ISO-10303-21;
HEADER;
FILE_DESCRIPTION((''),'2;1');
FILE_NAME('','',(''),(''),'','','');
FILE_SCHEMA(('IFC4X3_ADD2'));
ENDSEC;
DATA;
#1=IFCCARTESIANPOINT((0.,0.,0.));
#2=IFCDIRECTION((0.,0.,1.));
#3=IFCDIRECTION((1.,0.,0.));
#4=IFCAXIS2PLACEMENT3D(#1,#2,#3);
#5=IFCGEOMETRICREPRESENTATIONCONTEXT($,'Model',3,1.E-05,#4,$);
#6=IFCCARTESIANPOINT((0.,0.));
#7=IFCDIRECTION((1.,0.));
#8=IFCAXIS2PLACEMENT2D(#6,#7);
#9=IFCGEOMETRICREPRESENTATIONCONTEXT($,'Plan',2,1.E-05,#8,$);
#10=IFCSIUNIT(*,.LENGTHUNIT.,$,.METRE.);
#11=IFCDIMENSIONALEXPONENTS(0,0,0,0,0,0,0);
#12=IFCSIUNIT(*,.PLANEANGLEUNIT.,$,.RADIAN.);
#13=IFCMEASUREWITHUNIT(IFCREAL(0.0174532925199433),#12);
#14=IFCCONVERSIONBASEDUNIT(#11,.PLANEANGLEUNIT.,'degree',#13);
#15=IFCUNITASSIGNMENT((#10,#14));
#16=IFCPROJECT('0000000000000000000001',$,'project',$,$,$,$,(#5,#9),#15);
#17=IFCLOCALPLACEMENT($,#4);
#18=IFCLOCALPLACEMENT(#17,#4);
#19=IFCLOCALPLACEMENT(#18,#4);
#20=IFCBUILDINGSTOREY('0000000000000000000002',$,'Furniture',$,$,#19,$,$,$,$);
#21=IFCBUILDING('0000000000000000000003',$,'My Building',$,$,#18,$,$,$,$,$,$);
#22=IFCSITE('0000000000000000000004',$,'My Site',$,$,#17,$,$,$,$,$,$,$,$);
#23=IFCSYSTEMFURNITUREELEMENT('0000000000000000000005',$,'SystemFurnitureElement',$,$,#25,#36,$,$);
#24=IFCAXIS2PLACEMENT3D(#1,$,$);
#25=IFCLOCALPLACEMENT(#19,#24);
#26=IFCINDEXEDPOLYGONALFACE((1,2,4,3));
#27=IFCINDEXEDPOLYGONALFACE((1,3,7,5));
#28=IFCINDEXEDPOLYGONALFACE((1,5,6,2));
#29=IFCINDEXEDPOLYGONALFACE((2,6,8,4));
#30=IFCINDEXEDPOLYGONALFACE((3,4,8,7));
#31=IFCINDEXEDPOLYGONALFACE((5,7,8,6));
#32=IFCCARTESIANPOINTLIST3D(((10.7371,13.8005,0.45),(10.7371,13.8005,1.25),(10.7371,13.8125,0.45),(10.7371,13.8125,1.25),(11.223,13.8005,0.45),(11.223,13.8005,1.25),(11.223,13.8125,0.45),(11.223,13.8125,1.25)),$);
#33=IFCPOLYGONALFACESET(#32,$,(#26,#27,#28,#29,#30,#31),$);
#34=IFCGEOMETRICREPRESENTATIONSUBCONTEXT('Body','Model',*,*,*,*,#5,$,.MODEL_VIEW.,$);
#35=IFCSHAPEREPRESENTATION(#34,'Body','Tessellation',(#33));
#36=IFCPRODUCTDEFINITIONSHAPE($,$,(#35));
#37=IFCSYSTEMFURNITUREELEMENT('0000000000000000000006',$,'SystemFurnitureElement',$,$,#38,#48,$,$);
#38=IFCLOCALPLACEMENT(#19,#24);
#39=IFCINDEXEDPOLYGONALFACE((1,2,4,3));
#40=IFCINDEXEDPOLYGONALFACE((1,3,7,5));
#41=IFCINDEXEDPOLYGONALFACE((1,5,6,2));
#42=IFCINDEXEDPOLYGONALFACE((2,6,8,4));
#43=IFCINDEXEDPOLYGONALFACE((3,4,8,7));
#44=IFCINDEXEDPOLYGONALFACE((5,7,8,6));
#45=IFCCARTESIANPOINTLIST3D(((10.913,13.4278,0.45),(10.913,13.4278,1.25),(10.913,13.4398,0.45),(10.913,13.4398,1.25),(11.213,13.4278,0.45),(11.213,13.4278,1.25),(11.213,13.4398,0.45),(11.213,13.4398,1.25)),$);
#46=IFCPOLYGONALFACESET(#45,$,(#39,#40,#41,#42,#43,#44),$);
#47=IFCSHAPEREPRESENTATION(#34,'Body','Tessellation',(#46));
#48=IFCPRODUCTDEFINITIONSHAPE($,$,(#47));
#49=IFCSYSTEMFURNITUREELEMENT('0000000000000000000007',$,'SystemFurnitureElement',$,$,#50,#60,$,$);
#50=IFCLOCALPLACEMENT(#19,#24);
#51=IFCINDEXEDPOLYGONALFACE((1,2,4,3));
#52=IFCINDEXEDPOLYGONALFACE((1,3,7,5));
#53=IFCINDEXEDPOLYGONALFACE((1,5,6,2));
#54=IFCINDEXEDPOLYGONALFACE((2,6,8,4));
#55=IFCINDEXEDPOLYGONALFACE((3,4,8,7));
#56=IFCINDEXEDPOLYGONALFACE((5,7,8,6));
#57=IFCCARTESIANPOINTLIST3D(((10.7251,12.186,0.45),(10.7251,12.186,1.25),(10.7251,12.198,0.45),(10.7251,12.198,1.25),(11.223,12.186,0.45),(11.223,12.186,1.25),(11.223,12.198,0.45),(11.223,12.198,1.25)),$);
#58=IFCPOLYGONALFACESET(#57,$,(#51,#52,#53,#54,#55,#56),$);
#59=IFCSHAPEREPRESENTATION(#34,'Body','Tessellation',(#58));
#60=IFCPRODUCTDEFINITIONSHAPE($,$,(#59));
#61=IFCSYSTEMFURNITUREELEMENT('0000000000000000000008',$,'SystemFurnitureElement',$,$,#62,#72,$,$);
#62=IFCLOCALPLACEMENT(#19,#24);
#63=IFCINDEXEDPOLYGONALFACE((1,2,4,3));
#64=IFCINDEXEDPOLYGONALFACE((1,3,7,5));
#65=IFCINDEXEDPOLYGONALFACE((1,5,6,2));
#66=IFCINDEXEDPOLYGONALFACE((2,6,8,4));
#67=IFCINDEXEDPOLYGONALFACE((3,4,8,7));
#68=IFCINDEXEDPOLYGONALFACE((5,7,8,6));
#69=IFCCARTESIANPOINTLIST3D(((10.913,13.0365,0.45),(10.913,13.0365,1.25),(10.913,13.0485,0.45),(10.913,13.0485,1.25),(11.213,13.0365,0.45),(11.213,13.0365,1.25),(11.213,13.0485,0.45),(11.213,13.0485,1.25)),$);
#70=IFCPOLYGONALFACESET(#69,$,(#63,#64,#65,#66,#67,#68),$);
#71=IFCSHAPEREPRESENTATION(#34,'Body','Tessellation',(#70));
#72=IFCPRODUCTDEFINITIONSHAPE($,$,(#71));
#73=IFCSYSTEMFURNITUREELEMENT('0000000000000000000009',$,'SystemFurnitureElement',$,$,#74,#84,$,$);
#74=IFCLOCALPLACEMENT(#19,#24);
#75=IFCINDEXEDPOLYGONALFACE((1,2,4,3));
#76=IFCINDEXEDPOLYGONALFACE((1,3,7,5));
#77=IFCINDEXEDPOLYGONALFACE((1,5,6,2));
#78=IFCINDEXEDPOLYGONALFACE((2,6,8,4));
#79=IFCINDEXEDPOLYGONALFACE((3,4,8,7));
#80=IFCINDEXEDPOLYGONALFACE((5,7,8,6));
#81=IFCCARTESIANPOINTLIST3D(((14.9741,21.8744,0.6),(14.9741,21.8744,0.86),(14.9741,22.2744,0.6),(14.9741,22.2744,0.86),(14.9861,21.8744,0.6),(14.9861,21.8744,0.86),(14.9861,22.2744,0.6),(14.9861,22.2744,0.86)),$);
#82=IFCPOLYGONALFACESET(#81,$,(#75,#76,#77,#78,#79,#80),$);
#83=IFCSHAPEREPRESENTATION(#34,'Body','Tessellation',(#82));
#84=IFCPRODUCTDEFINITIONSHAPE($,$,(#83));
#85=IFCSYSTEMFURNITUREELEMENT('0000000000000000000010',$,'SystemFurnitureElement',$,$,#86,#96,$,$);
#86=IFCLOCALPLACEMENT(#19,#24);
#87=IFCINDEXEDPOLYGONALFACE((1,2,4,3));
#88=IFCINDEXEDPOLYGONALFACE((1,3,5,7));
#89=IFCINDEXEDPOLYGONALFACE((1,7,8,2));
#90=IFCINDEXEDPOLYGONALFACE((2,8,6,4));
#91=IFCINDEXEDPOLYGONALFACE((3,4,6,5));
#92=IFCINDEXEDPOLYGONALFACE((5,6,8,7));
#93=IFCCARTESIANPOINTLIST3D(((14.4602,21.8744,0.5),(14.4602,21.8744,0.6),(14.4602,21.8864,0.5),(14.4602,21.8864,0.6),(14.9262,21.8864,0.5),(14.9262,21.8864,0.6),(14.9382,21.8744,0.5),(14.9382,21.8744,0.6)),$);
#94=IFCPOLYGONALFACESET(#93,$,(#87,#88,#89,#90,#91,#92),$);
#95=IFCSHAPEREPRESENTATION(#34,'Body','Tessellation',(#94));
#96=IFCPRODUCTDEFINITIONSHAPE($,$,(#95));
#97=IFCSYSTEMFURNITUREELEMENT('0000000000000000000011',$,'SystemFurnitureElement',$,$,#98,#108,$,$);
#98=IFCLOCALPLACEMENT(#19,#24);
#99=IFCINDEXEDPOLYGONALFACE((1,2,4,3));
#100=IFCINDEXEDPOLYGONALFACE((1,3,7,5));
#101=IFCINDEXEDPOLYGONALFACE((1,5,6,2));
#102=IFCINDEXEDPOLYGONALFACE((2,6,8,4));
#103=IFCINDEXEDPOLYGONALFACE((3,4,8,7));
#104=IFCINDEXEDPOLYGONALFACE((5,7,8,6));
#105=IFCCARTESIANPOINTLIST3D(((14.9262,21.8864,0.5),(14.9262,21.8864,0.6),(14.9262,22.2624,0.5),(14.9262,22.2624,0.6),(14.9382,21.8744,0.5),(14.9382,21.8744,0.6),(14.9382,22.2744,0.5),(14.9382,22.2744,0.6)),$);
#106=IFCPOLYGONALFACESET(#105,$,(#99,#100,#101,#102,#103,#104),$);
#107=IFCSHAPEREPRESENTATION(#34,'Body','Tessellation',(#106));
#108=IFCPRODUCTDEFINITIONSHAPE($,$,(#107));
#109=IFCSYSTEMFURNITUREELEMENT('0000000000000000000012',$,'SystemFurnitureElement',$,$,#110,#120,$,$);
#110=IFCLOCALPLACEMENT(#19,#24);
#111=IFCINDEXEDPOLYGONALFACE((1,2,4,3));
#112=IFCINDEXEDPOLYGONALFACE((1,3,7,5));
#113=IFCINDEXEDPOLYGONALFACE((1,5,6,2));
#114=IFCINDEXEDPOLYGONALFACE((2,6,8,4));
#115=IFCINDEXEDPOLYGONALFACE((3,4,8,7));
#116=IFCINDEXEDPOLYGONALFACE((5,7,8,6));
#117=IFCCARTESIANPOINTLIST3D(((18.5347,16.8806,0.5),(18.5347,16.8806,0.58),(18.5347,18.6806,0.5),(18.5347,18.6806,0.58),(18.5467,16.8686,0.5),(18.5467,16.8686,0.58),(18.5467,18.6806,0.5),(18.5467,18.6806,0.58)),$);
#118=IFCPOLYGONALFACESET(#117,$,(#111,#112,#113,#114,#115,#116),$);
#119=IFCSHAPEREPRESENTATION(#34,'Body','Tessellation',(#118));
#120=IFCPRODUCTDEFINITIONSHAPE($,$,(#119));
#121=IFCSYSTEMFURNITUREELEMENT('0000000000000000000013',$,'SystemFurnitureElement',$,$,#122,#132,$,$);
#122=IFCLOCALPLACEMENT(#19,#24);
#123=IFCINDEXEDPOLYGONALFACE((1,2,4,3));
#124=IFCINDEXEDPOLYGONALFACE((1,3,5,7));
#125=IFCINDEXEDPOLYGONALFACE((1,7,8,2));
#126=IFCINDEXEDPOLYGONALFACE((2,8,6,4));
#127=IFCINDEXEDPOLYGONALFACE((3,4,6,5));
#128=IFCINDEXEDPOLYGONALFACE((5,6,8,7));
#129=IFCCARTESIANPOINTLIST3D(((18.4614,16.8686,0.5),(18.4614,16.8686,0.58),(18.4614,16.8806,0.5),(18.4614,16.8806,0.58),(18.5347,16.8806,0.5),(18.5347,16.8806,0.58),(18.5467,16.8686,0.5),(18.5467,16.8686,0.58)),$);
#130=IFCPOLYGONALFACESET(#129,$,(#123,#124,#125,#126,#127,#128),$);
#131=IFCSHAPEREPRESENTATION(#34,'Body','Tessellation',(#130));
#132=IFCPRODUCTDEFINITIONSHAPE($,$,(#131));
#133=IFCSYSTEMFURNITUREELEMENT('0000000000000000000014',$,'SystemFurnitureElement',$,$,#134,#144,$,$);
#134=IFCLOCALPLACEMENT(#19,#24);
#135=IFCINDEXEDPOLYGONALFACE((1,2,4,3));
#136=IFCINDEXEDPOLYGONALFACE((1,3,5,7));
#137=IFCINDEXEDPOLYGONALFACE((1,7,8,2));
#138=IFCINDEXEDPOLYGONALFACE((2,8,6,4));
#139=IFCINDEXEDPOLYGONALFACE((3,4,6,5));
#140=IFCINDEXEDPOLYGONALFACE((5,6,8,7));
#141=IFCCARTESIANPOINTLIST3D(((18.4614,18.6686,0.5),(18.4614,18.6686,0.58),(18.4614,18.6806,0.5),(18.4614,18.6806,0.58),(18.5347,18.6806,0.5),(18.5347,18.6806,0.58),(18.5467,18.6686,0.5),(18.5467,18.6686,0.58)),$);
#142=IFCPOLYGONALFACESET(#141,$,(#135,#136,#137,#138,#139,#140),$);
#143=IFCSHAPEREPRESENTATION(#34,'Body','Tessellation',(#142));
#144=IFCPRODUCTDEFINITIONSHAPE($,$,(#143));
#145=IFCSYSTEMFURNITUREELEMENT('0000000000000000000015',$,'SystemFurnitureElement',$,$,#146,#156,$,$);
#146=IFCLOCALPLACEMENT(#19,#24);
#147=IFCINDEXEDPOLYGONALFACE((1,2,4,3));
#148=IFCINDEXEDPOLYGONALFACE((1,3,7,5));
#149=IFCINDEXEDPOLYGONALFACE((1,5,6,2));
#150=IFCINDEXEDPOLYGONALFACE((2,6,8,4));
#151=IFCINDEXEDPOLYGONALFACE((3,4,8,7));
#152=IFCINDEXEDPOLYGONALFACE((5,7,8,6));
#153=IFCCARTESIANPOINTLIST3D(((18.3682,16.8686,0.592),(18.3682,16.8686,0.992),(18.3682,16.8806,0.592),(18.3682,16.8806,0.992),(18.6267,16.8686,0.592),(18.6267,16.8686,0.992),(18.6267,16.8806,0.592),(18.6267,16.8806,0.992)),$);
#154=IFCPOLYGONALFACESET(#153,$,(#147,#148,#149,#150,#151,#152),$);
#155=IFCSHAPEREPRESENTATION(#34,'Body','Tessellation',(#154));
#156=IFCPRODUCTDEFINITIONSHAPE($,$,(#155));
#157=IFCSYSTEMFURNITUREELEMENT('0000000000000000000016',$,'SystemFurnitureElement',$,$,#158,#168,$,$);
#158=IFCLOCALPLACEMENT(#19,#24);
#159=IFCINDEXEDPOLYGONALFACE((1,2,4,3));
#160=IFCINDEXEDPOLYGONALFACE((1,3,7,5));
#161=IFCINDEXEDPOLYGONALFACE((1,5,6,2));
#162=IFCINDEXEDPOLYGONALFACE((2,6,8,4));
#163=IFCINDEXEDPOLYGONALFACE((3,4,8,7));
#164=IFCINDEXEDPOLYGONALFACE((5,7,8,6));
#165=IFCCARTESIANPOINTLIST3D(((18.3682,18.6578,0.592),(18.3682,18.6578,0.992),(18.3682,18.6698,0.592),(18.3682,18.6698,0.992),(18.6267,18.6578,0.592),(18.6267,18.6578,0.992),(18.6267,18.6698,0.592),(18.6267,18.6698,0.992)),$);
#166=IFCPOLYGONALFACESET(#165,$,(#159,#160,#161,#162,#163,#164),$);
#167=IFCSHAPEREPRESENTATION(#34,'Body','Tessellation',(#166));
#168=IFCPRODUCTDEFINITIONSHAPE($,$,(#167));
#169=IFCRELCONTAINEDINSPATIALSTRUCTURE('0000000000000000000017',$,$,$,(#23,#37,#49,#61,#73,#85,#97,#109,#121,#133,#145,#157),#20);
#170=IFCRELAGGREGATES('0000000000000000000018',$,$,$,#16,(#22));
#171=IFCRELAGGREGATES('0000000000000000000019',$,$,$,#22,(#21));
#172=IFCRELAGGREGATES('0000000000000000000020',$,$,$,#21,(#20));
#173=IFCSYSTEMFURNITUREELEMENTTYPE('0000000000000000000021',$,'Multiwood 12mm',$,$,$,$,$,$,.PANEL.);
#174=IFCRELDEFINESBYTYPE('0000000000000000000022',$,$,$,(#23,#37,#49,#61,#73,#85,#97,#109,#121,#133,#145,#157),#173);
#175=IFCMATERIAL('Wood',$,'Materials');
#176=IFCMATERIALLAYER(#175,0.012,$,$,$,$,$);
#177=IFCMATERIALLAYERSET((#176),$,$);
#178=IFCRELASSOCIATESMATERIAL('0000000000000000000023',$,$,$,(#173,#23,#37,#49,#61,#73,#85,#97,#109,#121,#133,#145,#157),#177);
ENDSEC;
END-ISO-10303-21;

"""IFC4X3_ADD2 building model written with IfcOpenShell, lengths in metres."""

from ifc_helpers import new_model, entity, si_unit, converted_unit, frame, origin_with_axes, origin_2d_with_axis, place, context, subcontext, project, spatial, line, indexed_curve, outline, extrude, material, layer, layer_set, layer_usage, type_object, element, save


model = new_model("IFC4X3_ADD2")

# Units and contexts
model_context = context("Model", 3, precision=1e-05, world=origin_with_axes())
plan_context = context("Plan", 2, precision=1e-05, world=origin_2d_with_axis())
body_context = subcontext(model_context, "Body", "Model", "MODEL_VIEW")
ifc_project = project(units=[si_unit("LENGTHUNIT", "METRE"), converted_unit("PLANEANGLEUNIT", "degree", entity("IfcReal", 0.0174532925199433), si_unit("PLANEANGLEUNIT", "RADIAN"), dimensions=[0, 0, 0, 0, 0, 0, 0])], contexts=[model_context, plan_context])

# Site, building, storey
site_placement = place(None, origin_with_axes())
site = spatial("IfcSite", under=ifc_project, at=site_placement, Name="My Site")
building_placement = place(site_placement, origin_with_axes())
building = spatial("IfcBuilding", under=site, at=building_placement, Name="My Building")
storey_placement = place(building_placement, origin_with_axes())
storey = spatial("IfcBuildingStorey", under=building, at=storey_placement, Name="Furniture")

# System furniture elements
ifc_material = material(Name="Wood", Category="Materials")
ifc_layer_1 = layer(ifc_material, 0.012)
ifc_layer_set_1 = layer_set([ifc_layer_1])
ifc_layer_usage_1 = layer_usage(ifc_layer_set_1, "AXIS2", "POSITIVE", 0.0)
system_furniture_element_type_1 = type_object("IfcSystemFurnitureElementType", Name="Multiwood 12mm", PredefinedType="PANEL", material=ifc_layer_set_1)
system_furniture_element_1_placement = place(storey_placement, frame((11.223, 13.8125, 0.45), z_axis=(0.0, 0.0, 1.0), x_axis=(-1.0, 0.0, 0.0)))
element("IfcSystemFurnitureElement", 1, at=system_furniture_element_1_placement, inside=storey, type_object=system_furniture_element_type_1, material=ifc_layer_usage_1, Name="SystemFurnitureElement", context=body_context, shape_type="SweptSolid", body=[
    extrude(outline(indexed_curve([(0.0, 0.0), (0.0, 0.012), (0.4859, 0.012), (0.4859, 0.0)], segments=[line(1, 2, 3, 4, 1)])), origin_with_axes(), (0.0, 0.0, 1.0), 0.8),
])
ifc_layer_usage_2 = layer_usage(ifc_layer_set_1, "AXIS2", "POSITIVE", 0.0)
system_furniture_element_2_placement = place(storey_placement, frame((11.213, 13.4398, 0.45), z_axis=(0.0, 0.0, 1.0), x_axis=(-1.0, 0.0, 0.0)))
element("IfcSystemFurnitureElement", 2, at=system_furniture_element_2_placement, inside=storey, type_object=system_furniture_element_type_1, material=ifc_layer_usage_2, Name="SystemFurnitureElement", context=body_context, shape_type="SweptSolid", body=[
    extrude(outline(indexed_curve([(0.0, 0.0), (0.0, 0.012), (0.3, 0.012), (0.3, 0.0)], segments=[line(1, 2, 3, 4, 1)])), origin_with_axes(), (0.0, 0.0, 1.0), 0.8),
])
ifc_layer_usage_3 = layer_usage(ifc_layer_set_1, "AXIS2", "POSITIVE", 0.0)
system_furniture_element_3_placement = place(storey_placement, frame((11.223, 12.198, 0.45), z_axis=(0.0, 0.0, 1.0), x_axis=(-1.0, 0.0, 0.0)))
element("IfcSystemFurnitureElement", 3, at=system_furniture_element_3_placement, inside=storey, type_object=system_furniture_element_type_1, material=ifc_layer_usage_3, Name="SystemFurnitureElement", context=body_context, shape_type="SweptSolid", body=[
    extrude(outline(indexed_curve([(0.0, 0.0), (0.0, 0.012), (0.4979, 0.012), (0.4979, 0.0)], segments=[line(1, 2, 3, 4, 1)])), origin_with_axes(), (0.0, 0.0, 1.0), 0.8),
])
ifc_layer_usage_4 = layer_usage(ifc_layer_set_1, "AXIS2", "POSITIVE", 0.0)
system_furniture_element_4_placement = place(storey_placement, frame((11.213, 13.0485, 0.45), z_axis=(0.0, 0.0, 1.0), x_axis=(-1.0, 0.0, 0.0)))
element("IfcSystemFurnitureElement", 4, at=system_furniture_element_4_placement, inside=storey, type_object=system_furniture_element_type_1, material=ifc_layer_usage_4, Name="SystemFurnitureElement", context=body_context, shape_type="SweptSolid", body=[
    extrude(outline(indexed_curve([(0.0, 0.0), (0.0, 0.012), (0.3, 0.012), (0.3, 0.0)], segments=[line(1, 2, 3, 4, 1)])), origin_with_axes(), (0.0, 0.0, 1.0), 0.8),
])
ifc_layer_usage_5 = layer_usage(ifc_layer_set_1, "AXIS2", "POSITIVE", 0.0)
system_furniture_element_5_placement = place(storey_placement, frame((14.9861, 21.8744, 0.6), z_axis=(0.0, 0.0, 1.0), x_axis=(0.000001, 1.0, 0.0)))
element("IfcSystemFurnitureElement", 5, at=system_furniture_element_5_placement, inside=storey, type_object=system_furniture_element_type_1, material=ifc_layer_usage_5, Name="SystemFurnitureElement", context=body_context, shape_type="SweptSolid", body=[
    extrude(outline(indexed_curve([(0.0, 0.0), (0.0, 0.012), (0.4, 0.012), (0.4, 0.0)], segments=[line(1, 2, 3, 4, 1)])), origin_with_axes(), (0.0, 0.0, 1.0), 0.26),
])
ifc_layer_usage_6 = layer_usage(ifc_layer_set_1, "AXIS2", "POSITIVE", 0.0)
system_furniture_element_6_placement = place(storey_placement, frame((14.9382, 21.8864, 0.5), z_axis=(0.0, 0.0, 1.0), x_axis=(-1.0, 0.000001, 0.0)))
element("IfcSystemFurnitureElement", 6, at=system_furniture_element_6_placement, inside=storey, type_object=system_furniture_element_type_1, material=ifc_layer_usage_6, Name="SystemFurnitureElement", context=body_context, shape_type="SweptSolid", body=[
    extrude(outline(indexed_curve([(0.012, 0.0), (0.0, 0.012), (0.478, 0.012), (0.478, 0.0)], segments=[line(1, 2, 3, 4, 1)])), origin_with_axes(), (0.0, 0.0, 1.0), 0.1),
])
ifc_layer_usage_7 = layer_usage(ifc_layer_set_1, "AXIS2", "POSITIVE", 0.0)
system_furniture_element_7_placement = place(storey_placement, frame((14.9382, 21.8864, 0.5), z_axis=(0.0, 0.0, 1.0), x_axis=(0.000001, 1.0, 0.0)))
element("IfcSystemFurnitureElement", 7, at=system_furniture_element_7_placement, inside=storey, type_object=system_furniture_element_type_1, material=ifc_layer_usage_7, Name="SystemFurnitureElement", context=body_context, shape_type="SweptSolid", body=[
    extrude(outline(indexed_curve([(-0.012, 0.0), (0.0, 0.012), (0.376, 0.012), (0.388, 0.0)], segments=[line(1, 2, 3, 4, 1)])), origin_with_axes(), (0.0, 0.0, 1.0), 0.1),
])
ifc_layer_usage_8 = layer_usage(ifc_layer_set_1, "AXIS2", "POSITIVE", 0.0)
system_furniture_element_8_placement = place(storey_placement, frame((18.5467, 16.8806, 0.5), z_axis=(0.0, 0.0, 1.0), x_axis=(0.000001, 1.0, 0.0)))
element("IfcSystemFurnitureElement", 8, at=system_furniture_element_8_placement, inside=storey, type_object=system_furniture_element_type_1, material=ifc_layer_usage_8, Name="SystemFurnitureElement", context=body_context, shape_type="SweptSolid", body=[
    extrude(outline(indexed_curve([(-0.012, 0.0), (0.0, 0.012), (1.8, 0.012), (1.8, 0.0)], segments=[line(1, 2, 3, 4, 1)])), origin_with_axes(), (0.0, 0.0, 1.0), 0.08),
])
ifc_layer_usage_9 = layer_usage(ifc_layer_set_1, "AXIS2", "POSITIVE", 0.0)
system_furniture_element_9_placement = place(storey_placement, frame((18.5467, 16.8806, 0.5), z_axis=(0.0, 0.0, 1.0), x_axis=(-1.0, 0.000001, 0.0)))
element("IfcSystemFurnitureElement", 9, at=system_furniture_element_9_placement, inside=storey, type_object=system_furniture_element_type_1, material=ifc_layer_usage_9, Name="SystemFurnitureElement", context=body_context, shape_type="SweptSolid", body=[
    extrude(outline(indexed_curve([(0.012, 0.0), (0.0, 0.012), (0.0853, 0.012), (0.0853, 0.0)], segments=[line(1, 2, 3, 4, 1)])), origin_with_axes(), (0.0, 0.0, 1.0), 0.08),
])
ifc_layer_usage_10 = layer_usage(ifc_layer_set_1, "AXIS2", "POSITIVE", 0.0)
system_furniture_element_10_placement = place(storey_placement, frame((18.5467, 18.6806, 0.5), z_axis=(0.0, 0.0, 1.0), x_axis=(-1.0, 0.000001, 0.0)))
element("IfcSystemFurnitureElement", 10, at=system_furniture_element_10_placement, inside=storey, type_object=system_furniture_element_type_1, material=ifc_layer_usage_10, Name="SystemFurnitureElement", context=body_context, shape_type="SweptSolid", body=[
    extrude(outline(indexed_curve([(0.012, 0.0), (0.0, 0.012), (0.0853, 0.012), (0.0853, 0.0)], segments=[line(1, 2, 3, 4, 1)])), origin_with_axes(), (0.0, 0.0, 1.0), 0.08),
])
ifc_layer_usage_11 = layer_usage(ifc_layer_set_1, "AXIS2", "POSITIVE", 0.0)
system_furniture_element_11_placement = place(storey_placement, frame((18.6267, 16.8806, 0.592), z_axis=(0.0, 0.0, 1.0), x_axis=(-1.0, 0.000001, 0.0)))
element("IfcSystemFurnitureElement", 11, at=system_furniture_element_11_placement, inside=storey, type_object=system_furniture_element_type_1, material=ifc_layer_usage_11, Name="SystemFurnitureElement", context=body_context, shape_type="SweptSolid", body=[
    extrude(outline(indexed_curve([(0.0, 0.0), (0.0, 0.012), (0.2584, 0.012), (0.2584, 0.0)], segments=[line(1, 2, 3, 4, 1)])), origin_with_axes(), (0.0, 0.0, 1.0), 0.4),
])
ifc_layer_usage_12 = layer_usage(ifc_layer_set_1, "AXIS2", "POSITIVE", 0.0)
system_furniture_element_12_placement = place(storey_placement, frame((18.6267, 18.6698, 0.592), z_axis=(0.0, 0.0, 1.0), x_axis=(-1.0, 0.000001, 0.0)))
element("IfcSystemFurnitureElement", 12, at=system_furniture_element_12_placement, inside=storey, type_object=system_furniture_element_type_1, material=ifc_layer_usage_12, Name="SystemFurnitureElement", context=body_context, shape_type="SweptSolid", body=[
    extrude(outline(indexed_curve([(0.0, 0.0), (0.0, 0.012), (0.2584, 0.012), (0.2584, 0.0)], segments=[line(1, 2, 3, 4, 1)])), origin_with_axes(), (0.0, 0.0, 1.0), 0.4),
])

save(model, "model.ifc")
